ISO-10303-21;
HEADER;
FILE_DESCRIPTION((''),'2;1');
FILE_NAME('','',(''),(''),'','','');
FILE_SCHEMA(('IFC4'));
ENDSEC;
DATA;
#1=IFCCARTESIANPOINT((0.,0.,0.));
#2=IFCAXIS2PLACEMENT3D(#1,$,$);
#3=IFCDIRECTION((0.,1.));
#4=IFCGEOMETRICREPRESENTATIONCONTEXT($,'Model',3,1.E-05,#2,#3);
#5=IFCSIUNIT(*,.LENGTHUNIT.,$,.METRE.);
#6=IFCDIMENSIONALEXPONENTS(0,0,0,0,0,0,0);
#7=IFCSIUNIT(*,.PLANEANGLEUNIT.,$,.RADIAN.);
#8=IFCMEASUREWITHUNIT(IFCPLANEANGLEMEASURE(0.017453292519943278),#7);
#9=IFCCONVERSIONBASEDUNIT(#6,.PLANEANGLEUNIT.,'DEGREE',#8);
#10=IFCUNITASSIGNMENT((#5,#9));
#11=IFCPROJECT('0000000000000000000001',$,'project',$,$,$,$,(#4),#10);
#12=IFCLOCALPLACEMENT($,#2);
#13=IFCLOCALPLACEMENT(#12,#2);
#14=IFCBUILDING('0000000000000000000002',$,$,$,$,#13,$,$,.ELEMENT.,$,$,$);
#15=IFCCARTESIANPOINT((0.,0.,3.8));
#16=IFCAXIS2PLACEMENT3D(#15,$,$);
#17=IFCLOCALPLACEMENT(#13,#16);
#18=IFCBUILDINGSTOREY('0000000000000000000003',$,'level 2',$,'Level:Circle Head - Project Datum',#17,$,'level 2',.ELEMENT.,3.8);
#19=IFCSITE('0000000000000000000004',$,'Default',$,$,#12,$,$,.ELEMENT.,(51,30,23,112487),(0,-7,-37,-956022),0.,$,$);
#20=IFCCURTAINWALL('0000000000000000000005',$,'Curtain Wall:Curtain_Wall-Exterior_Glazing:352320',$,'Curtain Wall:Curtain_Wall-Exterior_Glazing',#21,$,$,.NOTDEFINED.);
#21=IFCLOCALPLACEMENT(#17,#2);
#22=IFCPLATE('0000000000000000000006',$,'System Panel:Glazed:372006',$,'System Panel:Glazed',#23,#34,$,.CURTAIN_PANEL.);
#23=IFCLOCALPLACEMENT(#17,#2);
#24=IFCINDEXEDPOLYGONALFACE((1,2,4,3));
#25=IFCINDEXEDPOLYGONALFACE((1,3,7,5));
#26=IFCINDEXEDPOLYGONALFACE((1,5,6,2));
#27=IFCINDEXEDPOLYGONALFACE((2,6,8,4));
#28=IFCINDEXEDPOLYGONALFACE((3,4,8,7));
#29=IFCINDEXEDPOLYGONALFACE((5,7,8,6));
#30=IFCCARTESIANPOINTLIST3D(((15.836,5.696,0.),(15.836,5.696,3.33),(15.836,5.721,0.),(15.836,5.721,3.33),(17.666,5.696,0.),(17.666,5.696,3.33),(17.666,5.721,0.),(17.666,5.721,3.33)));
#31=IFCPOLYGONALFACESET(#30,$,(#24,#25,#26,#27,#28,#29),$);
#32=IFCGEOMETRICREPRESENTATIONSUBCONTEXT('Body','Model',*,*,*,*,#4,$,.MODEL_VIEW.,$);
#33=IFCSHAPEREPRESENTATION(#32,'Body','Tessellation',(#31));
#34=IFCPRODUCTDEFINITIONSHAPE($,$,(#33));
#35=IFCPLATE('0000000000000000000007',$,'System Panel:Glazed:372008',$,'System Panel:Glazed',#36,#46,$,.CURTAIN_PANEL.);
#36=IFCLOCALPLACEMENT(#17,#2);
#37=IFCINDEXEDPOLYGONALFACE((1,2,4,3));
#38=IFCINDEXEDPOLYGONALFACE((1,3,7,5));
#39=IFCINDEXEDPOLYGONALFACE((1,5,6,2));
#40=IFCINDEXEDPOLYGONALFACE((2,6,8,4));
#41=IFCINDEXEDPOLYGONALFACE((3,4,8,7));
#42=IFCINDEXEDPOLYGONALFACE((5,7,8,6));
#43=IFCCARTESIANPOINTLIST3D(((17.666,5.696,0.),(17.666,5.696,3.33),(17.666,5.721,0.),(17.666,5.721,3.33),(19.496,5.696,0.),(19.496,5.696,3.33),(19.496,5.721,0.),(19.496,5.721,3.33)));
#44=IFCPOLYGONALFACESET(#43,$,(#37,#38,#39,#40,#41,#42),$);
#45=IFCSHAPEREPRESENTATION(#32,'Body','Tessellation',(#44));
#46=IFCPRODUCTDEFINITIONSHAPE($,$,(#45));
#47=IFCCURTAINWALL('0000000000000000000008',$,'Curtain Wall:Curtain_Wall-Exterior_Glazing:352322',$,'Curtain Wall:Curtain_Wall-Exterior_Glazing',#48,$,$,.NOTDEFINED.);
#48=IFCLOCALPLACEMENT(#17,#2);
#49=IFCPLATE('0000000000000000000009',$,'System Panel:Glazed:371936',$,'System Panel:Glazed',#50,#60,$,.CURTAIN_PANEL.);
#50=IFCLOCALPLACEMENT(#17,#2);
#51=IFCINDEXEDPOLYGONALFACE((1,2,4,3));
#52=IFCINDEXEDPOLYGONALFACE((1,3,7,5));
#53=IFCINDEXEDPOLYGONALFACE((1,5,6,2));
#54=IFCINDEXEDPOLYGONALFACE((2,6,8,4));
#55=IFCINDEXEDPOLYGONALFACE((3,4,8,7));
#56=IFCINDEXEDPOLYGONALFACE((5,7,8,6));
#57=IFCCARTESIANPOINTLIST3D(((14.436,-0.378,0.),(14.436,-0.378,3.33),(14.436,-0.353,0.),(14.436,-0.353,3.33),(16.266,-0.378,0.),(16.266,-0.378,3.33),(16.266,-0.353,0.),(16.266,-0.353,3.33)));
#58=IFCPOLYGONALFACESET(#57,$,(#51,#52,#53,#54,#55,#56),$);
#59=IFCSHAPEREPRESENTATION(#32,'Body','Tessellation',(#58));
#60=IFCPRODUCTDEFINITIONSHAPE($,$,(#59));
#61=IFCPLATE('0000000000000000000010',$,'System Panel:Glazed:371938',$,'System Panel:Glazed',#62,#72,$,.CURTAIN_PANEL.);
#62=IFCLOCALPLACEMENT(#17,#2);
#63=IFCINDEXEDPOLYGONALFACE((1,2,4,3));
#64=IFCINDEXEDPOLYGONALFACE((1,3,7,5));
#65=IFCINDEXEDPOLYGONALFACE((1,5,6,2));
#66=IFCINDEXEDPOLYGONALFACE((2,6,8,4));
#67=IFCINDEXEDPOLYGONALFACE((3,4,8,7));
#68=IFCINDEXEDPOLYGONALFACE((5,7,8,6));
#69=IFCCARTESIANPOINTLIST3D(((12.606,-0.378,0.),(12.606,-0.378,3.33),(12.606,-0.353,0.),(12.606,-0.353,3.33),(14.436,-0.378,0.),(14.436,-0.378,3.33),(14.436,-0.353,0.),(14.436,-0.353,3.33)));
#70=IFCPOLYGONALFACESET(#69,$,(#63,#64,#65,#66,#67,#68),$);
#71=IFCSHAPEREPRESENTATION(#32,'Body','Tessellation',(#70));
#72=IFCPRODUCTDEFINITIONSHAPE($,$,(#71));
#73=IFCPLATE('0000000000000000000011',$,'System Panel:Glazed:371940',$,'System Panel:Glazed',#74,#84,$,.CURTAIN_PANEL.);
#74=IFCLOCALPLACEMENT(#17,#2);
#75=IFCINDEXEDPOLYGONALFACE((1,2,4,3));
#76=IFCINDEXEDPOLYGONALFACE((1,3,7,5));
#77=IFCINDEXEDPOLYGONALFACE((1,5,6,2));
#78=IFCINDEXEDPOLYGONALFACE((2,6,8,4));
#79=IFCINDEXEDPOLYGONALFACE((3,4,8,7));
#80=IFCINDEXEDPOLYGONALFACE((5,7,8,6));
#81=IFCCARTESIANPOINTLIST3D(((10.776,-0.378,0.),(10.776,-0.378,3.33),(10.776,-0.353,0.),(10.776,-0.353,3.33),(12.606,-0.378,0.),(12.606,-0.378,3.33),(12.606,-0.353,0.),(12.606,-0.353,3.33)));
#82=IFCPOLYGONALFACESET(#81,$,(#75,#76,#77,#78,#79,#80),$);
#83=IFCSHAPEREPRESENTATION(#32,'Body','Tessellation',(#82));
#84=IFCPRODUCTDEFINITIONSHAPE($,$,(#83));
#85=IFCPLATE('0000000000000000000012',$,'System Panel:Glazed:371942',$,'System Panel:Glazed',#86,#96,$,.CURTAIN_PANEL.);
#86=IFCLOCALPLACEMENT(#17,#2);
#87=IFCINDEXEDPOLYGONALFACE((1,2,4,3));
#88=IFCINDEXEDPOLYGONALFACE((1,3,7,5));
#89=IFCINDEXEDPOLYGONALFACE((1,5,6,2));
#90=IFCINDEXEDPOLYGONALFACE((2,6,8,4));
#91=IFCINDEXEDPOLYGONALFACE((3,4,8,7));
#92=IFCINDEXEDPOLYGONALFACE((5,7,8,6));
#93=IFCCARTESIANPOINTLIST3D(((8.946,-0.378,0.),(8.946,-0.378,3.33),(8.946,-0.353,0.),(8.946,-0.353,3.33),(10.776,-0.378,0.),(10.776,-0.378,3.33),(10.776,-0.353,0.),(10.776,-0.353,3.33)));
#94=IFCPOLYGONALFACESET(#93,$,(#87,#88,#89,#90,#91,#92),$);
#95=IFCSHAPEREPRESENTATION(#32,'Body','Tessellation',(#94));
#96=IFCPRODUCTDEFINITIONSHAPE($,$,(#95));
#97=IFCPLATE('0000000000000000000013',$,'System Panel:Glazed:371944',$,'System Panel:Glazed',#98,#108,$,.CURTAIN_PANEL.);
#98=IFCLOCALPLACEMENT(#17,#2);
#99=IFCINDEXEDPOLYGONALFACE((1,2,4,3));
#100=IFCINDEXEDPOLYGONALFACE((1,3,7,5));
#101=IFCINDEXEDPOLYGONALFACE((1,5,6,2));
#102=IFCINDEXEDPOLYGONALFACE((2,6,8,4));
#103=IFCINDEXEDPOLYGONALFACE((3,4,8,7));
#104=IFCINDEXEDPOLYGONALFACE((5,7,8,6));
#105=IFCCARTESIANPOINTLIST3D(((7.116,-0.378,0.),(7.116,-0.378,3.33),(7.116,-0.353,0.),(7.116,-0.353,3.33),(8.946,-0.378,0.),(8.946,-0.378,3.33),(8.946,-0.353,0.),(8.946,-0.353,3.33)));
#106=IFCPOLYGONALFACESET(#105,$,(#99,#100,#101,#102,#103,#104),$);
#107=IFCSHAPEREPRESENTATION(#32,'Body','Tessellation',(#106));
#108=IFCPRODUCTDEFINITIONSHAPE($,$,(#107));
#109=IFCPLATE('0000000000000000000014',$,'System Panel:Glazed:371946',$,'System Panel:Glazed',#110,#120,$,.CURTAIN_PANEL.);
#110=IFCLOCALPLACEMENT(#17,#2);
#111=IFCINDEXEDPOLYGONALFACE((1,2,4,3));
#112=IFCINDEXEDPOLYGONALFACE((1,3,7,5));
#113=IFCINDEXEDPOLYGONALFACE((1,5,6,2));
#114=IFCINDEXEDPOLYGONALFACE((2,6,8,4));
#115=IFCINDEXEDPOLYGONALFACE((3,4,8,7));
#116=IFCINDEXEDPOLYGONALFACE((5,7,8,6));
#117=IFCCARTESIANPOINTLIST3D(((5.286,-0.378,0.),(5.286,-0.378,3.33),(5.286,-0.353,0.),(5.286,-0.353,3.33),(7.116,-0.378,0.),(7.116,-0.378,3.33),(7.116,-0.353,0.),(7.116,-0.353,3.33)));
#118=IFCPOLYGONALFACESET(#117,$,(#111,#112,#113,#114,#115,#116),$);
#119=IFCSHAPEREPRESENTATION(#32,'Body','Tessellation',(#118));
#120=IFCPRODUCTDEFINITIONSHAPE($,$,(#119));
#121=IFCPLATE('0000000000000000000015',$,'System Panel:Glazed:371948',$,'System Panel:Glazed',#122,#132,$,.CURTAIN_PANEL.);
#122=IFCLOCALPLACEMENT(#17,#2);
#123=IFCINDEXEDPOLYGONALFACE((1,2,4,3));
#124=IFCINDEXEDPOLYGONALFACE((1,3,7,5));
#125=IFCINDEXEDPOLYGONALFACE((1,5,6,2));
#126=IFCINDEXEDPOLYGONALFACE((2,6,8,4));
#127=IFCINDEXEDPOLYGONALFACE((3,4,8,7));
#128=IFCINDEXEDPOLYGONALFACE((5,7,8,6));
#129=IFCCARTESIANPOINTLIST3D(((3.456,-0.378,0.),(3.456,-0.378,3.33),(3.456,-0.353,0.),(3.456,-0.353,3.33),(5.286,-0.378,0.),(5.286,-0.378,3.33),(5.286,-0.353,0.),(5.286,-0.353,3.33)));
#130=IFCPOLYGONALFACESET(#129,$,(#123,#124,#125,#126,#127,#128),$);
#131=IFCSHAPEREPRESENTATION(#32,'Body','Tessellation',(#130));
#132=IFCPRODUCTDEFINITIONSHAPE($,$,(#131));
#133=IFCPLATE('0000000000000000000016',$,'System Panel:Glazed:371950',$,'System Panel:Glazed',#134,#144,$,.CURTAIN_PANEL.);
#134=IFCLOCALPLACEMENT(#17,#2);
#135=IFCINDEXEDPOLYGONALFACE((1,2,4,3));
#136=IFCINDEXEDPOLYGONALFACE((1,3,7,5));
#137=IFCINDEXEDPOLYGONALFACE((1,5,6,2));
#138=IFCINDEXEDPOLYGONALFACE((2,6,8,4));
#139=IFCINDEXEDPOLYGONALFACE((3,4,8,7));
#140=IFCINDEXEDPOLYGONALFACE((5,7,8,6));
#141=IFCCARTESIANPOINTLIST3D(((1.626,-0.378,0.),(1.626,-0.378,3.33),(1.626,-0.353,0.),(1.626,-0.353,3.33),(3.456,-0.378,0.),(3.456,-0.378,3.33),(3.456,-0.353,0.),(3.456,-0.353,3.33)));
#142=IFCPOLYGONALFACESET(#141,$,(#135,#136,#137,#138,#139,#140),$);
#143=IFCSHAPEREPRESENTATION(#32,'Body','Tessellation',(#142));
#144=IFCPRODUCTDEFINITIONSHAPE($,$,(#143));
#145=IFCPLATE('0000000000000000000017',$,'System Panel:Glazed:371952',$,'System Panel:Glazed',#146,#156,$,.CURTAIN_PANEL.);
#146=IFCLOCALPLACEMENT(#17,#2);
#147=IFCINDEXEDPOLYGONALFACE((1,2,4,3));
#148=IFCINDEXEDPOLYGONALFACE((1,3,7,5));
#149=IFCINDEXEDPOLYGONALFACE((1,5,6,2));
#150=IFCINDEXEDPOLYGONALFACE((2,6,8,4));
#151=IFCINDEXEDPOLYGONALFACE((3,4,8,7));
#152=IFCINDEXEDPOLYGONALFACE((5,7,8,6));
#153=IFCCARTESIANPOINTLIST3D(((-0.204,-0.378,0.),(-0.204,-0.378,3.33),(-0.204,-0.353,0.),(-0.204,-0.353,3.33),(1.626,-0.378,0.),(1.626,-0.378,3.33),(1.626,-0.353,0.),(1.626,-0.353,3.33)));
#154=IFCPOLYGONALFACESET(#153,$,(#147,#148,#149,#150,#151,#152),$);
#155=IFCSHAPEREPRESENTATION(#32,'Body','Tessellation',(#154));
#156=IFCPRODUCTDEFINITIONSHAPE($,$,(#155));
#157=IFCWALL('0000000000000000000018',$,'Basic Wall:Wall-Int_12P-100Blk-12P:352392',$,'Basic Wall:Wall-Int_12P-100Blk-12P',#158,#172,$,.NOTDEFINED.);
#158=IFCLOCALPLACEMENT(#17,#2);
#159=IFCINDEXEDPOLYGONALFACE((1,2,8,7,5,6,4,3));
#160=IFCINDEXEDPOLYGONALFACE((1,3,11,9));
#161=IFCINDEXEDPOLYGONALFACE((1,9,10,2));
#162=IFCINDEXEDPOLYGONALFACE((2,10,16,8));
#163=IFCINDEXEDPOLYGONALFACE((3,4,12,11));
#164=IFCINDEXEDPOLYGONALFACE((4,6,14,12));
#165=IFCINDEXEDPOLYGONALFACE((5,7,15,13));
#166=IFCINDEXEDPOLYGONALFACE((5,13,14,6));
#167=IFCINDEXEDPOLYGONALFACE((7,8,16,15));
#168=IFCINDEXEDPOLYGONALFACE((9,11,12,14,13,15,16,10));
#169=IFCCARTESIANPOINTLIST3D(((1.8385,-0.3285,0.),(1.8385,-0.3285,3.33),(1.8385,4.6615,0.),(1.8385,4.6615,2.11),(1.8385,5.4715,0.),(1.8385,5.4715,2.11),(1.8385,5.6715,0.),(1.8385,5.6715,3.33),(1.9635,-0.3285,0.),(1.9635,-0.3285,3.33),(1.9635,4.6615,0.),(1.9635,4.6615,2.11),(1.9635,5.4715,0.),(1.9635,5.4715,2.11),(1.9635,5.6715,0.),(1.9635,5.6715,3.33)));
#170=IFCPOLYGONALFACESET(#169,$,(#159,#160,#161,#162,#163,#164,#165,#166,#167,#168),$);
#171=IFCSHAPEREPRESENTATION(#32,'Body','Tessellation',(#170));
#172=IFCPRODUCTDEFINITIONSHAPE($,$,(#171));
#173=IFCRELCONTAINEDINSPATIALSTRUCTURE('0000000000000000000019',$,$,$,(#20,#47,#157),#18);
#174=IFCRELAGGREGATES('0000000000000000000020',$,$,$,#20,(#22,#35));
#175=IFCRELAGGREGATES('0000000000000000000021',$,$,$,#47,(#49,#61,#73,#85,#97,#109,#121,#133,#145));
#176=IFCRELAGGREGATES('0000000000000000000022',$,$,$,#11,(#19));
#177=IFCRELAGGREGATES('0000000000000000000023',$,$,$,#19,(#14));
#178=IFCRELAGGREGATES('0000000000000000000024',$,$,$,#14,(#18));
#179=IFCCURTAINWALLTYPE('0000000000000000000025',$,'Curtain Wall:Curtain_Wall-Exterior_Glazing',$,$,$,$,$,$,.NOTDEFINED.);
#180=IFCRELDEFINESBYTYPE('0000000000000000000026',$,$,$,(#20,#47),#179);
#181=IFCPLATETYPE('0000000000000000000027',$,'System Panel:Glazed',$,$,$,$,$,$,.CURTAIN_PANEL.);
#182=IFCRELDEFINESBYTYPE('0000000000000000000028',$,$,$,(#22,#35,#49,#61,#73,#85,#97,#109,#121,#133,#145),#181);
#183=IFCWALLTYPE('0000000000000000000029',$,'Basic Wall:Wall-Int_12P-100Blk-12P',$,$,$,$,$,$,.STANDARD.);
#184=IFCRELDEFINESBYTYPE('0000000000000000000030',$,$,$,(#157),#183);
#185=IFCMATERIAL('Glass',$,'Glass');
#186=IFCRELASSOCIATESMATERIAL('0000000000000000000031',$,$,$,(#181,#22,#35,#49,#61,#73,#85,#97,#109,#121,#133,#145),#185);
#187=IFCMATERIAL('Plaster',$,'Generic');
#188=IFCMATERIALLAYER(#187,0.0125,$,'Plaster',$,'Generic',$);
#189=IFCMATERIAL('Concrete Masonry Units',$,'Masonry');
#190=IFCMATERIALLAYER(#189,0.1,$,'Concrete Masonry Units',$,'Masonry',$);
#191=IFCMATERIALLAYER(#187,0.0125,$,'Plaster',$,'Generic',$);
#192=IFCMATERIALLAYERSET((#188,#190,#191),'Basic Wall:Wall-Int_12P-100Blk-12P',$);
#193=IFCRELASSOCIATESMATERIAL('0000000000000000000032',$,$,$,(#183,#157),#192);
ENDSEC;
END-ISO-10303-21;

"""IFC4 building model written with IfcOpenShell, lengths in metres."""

from ifc_helpers import new_model, entity, si_unit, converted_unit, direction, frame, frame_2d, origin, origin_2d_with_axis, place, context, subcontext, project, spatial, polyline, rectangle, extrude, clip, bounded_halfspace, source, transform, mapped, material, layer, layer_set, layer_usage, type_object, type_shapes, element, aggregate, save


model = new_model("IFC4")

# Units and contexts
model_context = context("Model", 3, precision=1e-05, world=origin(), true_north=direction((0.0, 1.0)))
body_context = subcontext(model_context, "Body", "Model", "MODEL_VIEW")
ifc_project = project(units=[si_unit("LENGTHUNIT", "METRE"), converted_unit("PLANEANGLEUNIT", "DEGREE", entity("IfcPlaneAngleMeasure", 0.017453292519943278), si_unit("PLANEANGLEUNIT", "RADIAN"), dimensions=[0, 0, 0, 0, 0, 0, 0])], contexts=[model_context])

# Site, building, storey
site_placement = place(None, origin())
site = spatial("IfcSite", under=ifc_project, at=site_placement, Name="Default", CompositionType="ELEMENT", RefLatitude=(51, 30, 23, 112487), RefLongitude=(0, -7, -37, -956022), RefElevation=0.0)
building_placement = place(site_placement, origin())
building = spatial("IfcBuilding", under=site, at=building_placement, CompositionType="ELEMENT")
storey_placement = place(building_placement, frame((0.0, 0.0, 3.8)))
storey = spatial("IfcBuildingStorey", under=building, at=storey_placement, Name="level 2", ObjectType="Level:Circle Head - Project Datum", LongName="level 2", CompositionType="ELEMENT", Elevation=3.8)

# Curtain walls, plates
curtain_wall_type = type_object("IfcCurtainWallType", Name="Curtain Wall:Curtain_Wall-Exterior_Glazing", PredefinedType="NOTDEFINED")
curtain_wall_1_placement = place(storey_placement, frame((0.0, 0.0, -3.8)))
curtain_wall_1 = element("IfcCurtainWall", 1, at=curtain_wall_1_placement, inside=storey, type_object=curtain_wall_type, Name="Curtain Wall:Curtain_Wall-Exterior_Glazing:352320", ObjectType="Curtain Wall:Curtain_Wall-Exterior_Glazing", PredefinedType="NOTDEFINED")
ifc_material_1 = material(Name="Glass", Category="Glass")
plate_type = type_object("IfcPlateType", Name="System Panel:Glazed", PredefinedType="CURTAIN_PANEL", material=ifc_material_1)
shared_shape_1 = source(origin(), body_context, "Body", "SweptSolid", [
    extrude(rectangle(XDim=0.025, YDim=1.83, at=origin_2d_with_axis()), frame((0.915, 0.0125, 0.0), z_axis=(0.0, 0.0, 1.0), x_axis=(0.0, 1.0, 0.0)), (0.0, 0.0, 1.0), 3.33),
])
type_shapes(plate_type, [shared_shape_1])
plate_1_placement = place(curtain_wall_1_placement, frame((15.836, 5.696, 3.8)))
plate_1 = element("IfcPlate", 2, at=plate_1_placement, type_object=plate_type, material=ifc_material_1, Name="System Panel:Glazed:372006", ObjectType="System Panel:Glazed", PredefinedType="CURTAIN_PANEL", context=body_context, shape_type="MappedRepresentation", body=[
    mapped(shared_shape_1, transform((0.0, 0.0, 0.0), scale=1.0)),
])
plate_2_placement = place(curtain_wall_1_placement, frame((17.666, 5.696, 3.8)))
plate_2 = element("IfcPlate", 3, at=plate_2_placement, type_object=plate_type, material=ifc_material_1, Name="System Panel:Glazed:372008", ObjectType="System Panel:Glazed", PredefinedType="CURTAIN_PANEL", context=body_context, shape_type="MappedRepresentation", body=[
    mapped(shared_shape_1, transform((0.0, 0.0, 0.0), scale=1.0)),
])
aggregate(curtain_wall_1, [plate_1, plate_2])
curtain_wall_2_placement = place(storey_placement, frame((0.0, 0.0, -3.8)))
curtain_wall_2 = element("IfcCurtainWall", 4, at=curtain_wall_2_placement, inside=storey, type_object=curtain_wall_type, Name="Curtain Wall:Curtain_Wall-Exterior_Glazing:352322", ObjectType="Curtain Wall:Curtain_Wall-Exterior_Glazing", PredefinedType="NOTDEFINED")
plate_3_placement = place(curtain_wall_2_placement, frame((16.266, -0.353, 3.8), z_axis=(0.0, 0.0, 1.0), x_axis=(-1.0, 0.0, 0.0)))
plate_3 = element("IfcPlate", 5, at=plate_3_placement, type_object=plate_type, material=ifc_material_1, Name="System Panel:Glazed:371936", ObjectType="System Panel:Glazed", PredefinedType="CURTAIN_PANEL", context=body_context, shape_type="MappedRepresentation", body=[
    mapped(shared_shape_1, transform((0.0, 0.0, 0.0), scale=1.0)),
])
plate_4_placement = place(curtain_wall_2_placement, frame((14.436, -0.353, 3.8), z_axis=(0.0, 0.0, 1.0), x_axis=(-1.0, 0.0, 0.0)))
plate_4 = element("IfcPlate", 6, at=plate_4_placement, type_object=plate_type, material=ifc_material_1, Name="System Panel:Glazed:371938", ObjectType="System Panel:Glazed", PredefinedType="CURTAIN_PANEL", context=body_context, shape_type="MappedRepresentation", body=[
    mapped(shared_shape_1, transform((0.0, 0.0, 0.0), scale=1.0)),
])
plate_5_placement = place(curtain_wall_2_placement, frame((12.606, -0.353, 3.8), z_axis=(0.0, 0.0, 1.0), x_axis=(-1.0, 0.0, 0.0)))
plate_5 = element("IfcPlate", 7, at=plate_5_placement, type_object=plate_type, material=ifc_material_1, Name="System Panel:Glazed:371940", ObjectType="System Panel:Glazed", PredefinedType="CURTAIN_PANEL", context=body_context, shape_type="MappedRepresentation", body=[
    mapped(shared_shape_1, transform((0.0, 0.0, 0.0), scale=1.0)),
])
plate_6_placement = place(curtain_wall_2_placement, frame((10.776, -0.353, 3.8), z_axis=(0.0, 0.0, 1.0), x_axis=(-1.0, 0.0, 0.0)))
plate_6 = element("IfcPlate", 8, at=plate_6_placement, type_object=plate_type, material=ifc_material_1, Name="System Panel:Glazed:371942", ObjectType="System Panel:Glazed", PredefinedType="CURTAIN_PANEL", context=body_context, shape_type="MappedRepresentation", body=[
    mapped(shared_shape_1, transform((0.0, 0.0, 0.0), scale=1.0)),
])
plate_7_placement = place(curtain_wall_2_placement, frame((8.946, -0.353, 3.8), z_axis=(0.0, 0.0, 1.0), x_axis=(-1.0, 0.0, 0.0)))
plate_7 = element("IfcPlate", 9, at=plate_7_placement, type_object=plate_type, material=ifc_material_1, Name="System Panel:Glazed:371944", ObjectType="System Panel:Glazed", PredefinedType="CURTAIN_PANEL", context=body_context, shape_type="MappedRepresentation", body=[
    mapped(shared_shape_1, transform((0.0, 0.0, 0.0), scale=1.0)),
])
plate_8_placement = place(curtain_wall_2_placement, frame((7.116, -0.353, 3.8), z_axis=(0.0, 0.0, 1.0), x_axis=(-1.0, 0.0, 0.0)))
plate_8 = element("IfcPlate", 10, at=plate_8_placement, type_object=plate_type, material=ifc_material_1, Name="System Panel:Glazed:371946", ObjectType="System Panel:Glazed", PredefinedType="CURTAIN_PANEL", context=body_context, shape_type="MappedRepresentation", body=[
    mapped(shared_shape_1, transform((0.0, 0.0, 0.0), scale=1.0)),
])
plate_9_placement = place(curtain_wall_2_placement, frame((5.286, -0.353, 3.8), z_axis=(0.0, 0.0, 1.0), x_axis=(-1.0, 0.0, 0.0)))
plate_9 = element("IfcPlate", 11, at=plate_9_placement, type_object=plate_type, material=ifc_material_1, Name="System Panel:Glazed:371948", ObjectType="System Panel:Glazed", PredefinedType="CURTAIN_PANEL", context=body_context, shape_type="MappedRepresentation", body=[
    mapped(shared_shape_1, transform((0.0, 0.0, 0.0), scale=1.0)),
])
plate_10_placement = place(curtain_wall_2_placement, frame((3.456, -0.353, 3.8), z_axis=(0.0, 0.0, 1.0), x_axis=(-1.0, 0.0, 0.0)))
plate_10 = element("IfcPlate", 12, at=plate_10_placement, type_object=plate_type, material=ifc_material_1, Name="System Panel:Glazed:371950", ObjectType="System Panel:Glazed", PredefinedType="CURTAIN_PANEL", context=body_context, shape_type="MappedRepresentation", body=[
    mapped(shared_shape_1, transform((0.0, 0.0, 0.0), scale=1.0)),
])
plate_11_placement = place(curtain_wall_2_placement, frame((1.626, -0.353, 3.8), z_axis=(0.0, 0.0, 1.0), x_axis=(-1.0, 0.0, 0.0)))
plate_11 = element("IfcPlate", 13, at=plate_11_placement, type_object=plate_type, material=ifc_material_1, Name="System Panel:Glazed:371952", ObjectType="System Panel:Glazed", PredefinedType="CURTAIN_PANEL", context=body_context, shape_type="MappedRepresentation", body=[
    mapped(shared_shape_1, transform((0.0, 0.0, 0.0), scale=1.0)),
])
aggregate(curtain_wall_2, [plate_3, plate_4, plate_5, plate_6, plate_7, plate_8, plate_9, plate_10, plate_11])

# Wall, opening
ifc_material_2 = material(Name="Plaster", Category="Generic")
ifc_layer_1 = layer(ifc_material_2, 0.0125, Name="Plaster", Category="Generic")
ifc_material_3 = material(Name="Concrete Masonry Units", Category="Masonry")
ifc_layer_2 = layer(ifc_material_3, 0.1, Name="Concrete Masonry Units", Category="Masonry")
ifc_layer_3 = layer(ifc_material_2, 0.0125, Name="Plaster", Category="Generic")
ifc_layer_set = layer_set([ifc_layer_1, ifc_layer_2, ifc_layer_3], Name="Basic Wall:Wall-Int_12P-100Blk-12P")
ifc_layer_usage_1 = layer_usage(ifc_layer_set, "AXIS2", "NEGATIVE", 0.0625)
wall_type = type_object("IfcWallType", Name="Basic Wall:Wall-Int_12P-100Blk-12P", PredefinedType="STANDARD", material=ifc_layer_set)
wall_1_placement = place(storey_placement, frame((1.901, 5.6715, 0.0), z_axis=(0.0, 0.0, 1.0), x_axis=(0.0, -1.0, 0.0)))
wall_1 = element("IfcWall", 14, at=wall_1_placement, inside=storey, type_object=wall_type, material=ifc_layer_usage_1, Name="Basic Wall:Wall-Int_12P-100Blk-12P:352392", ObjectType="Basic Wall:Wall-Int_12P-100Blk-12P", PredefinedType="NOTDEFINED", context=body_context, shape_type="Clipping", body=[
    clip(extrude(rectangle(XDim=6.0, YDim=0.125, at=frame_2d((3.0, 0.0), x_axis=(1.0, 0.0))), origin(), (0.0, 0.0, 1.0), 3.33), bounded_halfspace(frame((0.0, -0.0625, 3.33), z_axis=(0.0, 0.0, -1.0), x_axis=(-1.0, 0.0, 0.0)), True, frame((0.0, -0.0625, 3.33)), polyline([(0.0, 0.0), (6.0, 0.0), (6.0, 0.125), (0.0, 0.125), (0.0, 0.0)]))),
])
opening_1_placement = place(wall_1_placement, frame((0.2, -0.0625, 0.0)))
element("IfcOpeningElement", 15, at=opening_1_placement, cuts=wall_1, PredefinedType="OPENING", context=body_context, shape_type="SweptSolid", body=[
    extrude(rectangle(XDim=2.11, YDim=0.81, at=frame_2d((1.055, 0.405), x_axis=(1.0, 0.0))), frame((0.0, 0.0, 0.0), z_axis=(0.0, 1.0, 0.0), x_axis=(0.0, 0.0, 1.0)), (0.0, 0.0, 1.0), 0.125),
])

save(model, "model.ifc")
